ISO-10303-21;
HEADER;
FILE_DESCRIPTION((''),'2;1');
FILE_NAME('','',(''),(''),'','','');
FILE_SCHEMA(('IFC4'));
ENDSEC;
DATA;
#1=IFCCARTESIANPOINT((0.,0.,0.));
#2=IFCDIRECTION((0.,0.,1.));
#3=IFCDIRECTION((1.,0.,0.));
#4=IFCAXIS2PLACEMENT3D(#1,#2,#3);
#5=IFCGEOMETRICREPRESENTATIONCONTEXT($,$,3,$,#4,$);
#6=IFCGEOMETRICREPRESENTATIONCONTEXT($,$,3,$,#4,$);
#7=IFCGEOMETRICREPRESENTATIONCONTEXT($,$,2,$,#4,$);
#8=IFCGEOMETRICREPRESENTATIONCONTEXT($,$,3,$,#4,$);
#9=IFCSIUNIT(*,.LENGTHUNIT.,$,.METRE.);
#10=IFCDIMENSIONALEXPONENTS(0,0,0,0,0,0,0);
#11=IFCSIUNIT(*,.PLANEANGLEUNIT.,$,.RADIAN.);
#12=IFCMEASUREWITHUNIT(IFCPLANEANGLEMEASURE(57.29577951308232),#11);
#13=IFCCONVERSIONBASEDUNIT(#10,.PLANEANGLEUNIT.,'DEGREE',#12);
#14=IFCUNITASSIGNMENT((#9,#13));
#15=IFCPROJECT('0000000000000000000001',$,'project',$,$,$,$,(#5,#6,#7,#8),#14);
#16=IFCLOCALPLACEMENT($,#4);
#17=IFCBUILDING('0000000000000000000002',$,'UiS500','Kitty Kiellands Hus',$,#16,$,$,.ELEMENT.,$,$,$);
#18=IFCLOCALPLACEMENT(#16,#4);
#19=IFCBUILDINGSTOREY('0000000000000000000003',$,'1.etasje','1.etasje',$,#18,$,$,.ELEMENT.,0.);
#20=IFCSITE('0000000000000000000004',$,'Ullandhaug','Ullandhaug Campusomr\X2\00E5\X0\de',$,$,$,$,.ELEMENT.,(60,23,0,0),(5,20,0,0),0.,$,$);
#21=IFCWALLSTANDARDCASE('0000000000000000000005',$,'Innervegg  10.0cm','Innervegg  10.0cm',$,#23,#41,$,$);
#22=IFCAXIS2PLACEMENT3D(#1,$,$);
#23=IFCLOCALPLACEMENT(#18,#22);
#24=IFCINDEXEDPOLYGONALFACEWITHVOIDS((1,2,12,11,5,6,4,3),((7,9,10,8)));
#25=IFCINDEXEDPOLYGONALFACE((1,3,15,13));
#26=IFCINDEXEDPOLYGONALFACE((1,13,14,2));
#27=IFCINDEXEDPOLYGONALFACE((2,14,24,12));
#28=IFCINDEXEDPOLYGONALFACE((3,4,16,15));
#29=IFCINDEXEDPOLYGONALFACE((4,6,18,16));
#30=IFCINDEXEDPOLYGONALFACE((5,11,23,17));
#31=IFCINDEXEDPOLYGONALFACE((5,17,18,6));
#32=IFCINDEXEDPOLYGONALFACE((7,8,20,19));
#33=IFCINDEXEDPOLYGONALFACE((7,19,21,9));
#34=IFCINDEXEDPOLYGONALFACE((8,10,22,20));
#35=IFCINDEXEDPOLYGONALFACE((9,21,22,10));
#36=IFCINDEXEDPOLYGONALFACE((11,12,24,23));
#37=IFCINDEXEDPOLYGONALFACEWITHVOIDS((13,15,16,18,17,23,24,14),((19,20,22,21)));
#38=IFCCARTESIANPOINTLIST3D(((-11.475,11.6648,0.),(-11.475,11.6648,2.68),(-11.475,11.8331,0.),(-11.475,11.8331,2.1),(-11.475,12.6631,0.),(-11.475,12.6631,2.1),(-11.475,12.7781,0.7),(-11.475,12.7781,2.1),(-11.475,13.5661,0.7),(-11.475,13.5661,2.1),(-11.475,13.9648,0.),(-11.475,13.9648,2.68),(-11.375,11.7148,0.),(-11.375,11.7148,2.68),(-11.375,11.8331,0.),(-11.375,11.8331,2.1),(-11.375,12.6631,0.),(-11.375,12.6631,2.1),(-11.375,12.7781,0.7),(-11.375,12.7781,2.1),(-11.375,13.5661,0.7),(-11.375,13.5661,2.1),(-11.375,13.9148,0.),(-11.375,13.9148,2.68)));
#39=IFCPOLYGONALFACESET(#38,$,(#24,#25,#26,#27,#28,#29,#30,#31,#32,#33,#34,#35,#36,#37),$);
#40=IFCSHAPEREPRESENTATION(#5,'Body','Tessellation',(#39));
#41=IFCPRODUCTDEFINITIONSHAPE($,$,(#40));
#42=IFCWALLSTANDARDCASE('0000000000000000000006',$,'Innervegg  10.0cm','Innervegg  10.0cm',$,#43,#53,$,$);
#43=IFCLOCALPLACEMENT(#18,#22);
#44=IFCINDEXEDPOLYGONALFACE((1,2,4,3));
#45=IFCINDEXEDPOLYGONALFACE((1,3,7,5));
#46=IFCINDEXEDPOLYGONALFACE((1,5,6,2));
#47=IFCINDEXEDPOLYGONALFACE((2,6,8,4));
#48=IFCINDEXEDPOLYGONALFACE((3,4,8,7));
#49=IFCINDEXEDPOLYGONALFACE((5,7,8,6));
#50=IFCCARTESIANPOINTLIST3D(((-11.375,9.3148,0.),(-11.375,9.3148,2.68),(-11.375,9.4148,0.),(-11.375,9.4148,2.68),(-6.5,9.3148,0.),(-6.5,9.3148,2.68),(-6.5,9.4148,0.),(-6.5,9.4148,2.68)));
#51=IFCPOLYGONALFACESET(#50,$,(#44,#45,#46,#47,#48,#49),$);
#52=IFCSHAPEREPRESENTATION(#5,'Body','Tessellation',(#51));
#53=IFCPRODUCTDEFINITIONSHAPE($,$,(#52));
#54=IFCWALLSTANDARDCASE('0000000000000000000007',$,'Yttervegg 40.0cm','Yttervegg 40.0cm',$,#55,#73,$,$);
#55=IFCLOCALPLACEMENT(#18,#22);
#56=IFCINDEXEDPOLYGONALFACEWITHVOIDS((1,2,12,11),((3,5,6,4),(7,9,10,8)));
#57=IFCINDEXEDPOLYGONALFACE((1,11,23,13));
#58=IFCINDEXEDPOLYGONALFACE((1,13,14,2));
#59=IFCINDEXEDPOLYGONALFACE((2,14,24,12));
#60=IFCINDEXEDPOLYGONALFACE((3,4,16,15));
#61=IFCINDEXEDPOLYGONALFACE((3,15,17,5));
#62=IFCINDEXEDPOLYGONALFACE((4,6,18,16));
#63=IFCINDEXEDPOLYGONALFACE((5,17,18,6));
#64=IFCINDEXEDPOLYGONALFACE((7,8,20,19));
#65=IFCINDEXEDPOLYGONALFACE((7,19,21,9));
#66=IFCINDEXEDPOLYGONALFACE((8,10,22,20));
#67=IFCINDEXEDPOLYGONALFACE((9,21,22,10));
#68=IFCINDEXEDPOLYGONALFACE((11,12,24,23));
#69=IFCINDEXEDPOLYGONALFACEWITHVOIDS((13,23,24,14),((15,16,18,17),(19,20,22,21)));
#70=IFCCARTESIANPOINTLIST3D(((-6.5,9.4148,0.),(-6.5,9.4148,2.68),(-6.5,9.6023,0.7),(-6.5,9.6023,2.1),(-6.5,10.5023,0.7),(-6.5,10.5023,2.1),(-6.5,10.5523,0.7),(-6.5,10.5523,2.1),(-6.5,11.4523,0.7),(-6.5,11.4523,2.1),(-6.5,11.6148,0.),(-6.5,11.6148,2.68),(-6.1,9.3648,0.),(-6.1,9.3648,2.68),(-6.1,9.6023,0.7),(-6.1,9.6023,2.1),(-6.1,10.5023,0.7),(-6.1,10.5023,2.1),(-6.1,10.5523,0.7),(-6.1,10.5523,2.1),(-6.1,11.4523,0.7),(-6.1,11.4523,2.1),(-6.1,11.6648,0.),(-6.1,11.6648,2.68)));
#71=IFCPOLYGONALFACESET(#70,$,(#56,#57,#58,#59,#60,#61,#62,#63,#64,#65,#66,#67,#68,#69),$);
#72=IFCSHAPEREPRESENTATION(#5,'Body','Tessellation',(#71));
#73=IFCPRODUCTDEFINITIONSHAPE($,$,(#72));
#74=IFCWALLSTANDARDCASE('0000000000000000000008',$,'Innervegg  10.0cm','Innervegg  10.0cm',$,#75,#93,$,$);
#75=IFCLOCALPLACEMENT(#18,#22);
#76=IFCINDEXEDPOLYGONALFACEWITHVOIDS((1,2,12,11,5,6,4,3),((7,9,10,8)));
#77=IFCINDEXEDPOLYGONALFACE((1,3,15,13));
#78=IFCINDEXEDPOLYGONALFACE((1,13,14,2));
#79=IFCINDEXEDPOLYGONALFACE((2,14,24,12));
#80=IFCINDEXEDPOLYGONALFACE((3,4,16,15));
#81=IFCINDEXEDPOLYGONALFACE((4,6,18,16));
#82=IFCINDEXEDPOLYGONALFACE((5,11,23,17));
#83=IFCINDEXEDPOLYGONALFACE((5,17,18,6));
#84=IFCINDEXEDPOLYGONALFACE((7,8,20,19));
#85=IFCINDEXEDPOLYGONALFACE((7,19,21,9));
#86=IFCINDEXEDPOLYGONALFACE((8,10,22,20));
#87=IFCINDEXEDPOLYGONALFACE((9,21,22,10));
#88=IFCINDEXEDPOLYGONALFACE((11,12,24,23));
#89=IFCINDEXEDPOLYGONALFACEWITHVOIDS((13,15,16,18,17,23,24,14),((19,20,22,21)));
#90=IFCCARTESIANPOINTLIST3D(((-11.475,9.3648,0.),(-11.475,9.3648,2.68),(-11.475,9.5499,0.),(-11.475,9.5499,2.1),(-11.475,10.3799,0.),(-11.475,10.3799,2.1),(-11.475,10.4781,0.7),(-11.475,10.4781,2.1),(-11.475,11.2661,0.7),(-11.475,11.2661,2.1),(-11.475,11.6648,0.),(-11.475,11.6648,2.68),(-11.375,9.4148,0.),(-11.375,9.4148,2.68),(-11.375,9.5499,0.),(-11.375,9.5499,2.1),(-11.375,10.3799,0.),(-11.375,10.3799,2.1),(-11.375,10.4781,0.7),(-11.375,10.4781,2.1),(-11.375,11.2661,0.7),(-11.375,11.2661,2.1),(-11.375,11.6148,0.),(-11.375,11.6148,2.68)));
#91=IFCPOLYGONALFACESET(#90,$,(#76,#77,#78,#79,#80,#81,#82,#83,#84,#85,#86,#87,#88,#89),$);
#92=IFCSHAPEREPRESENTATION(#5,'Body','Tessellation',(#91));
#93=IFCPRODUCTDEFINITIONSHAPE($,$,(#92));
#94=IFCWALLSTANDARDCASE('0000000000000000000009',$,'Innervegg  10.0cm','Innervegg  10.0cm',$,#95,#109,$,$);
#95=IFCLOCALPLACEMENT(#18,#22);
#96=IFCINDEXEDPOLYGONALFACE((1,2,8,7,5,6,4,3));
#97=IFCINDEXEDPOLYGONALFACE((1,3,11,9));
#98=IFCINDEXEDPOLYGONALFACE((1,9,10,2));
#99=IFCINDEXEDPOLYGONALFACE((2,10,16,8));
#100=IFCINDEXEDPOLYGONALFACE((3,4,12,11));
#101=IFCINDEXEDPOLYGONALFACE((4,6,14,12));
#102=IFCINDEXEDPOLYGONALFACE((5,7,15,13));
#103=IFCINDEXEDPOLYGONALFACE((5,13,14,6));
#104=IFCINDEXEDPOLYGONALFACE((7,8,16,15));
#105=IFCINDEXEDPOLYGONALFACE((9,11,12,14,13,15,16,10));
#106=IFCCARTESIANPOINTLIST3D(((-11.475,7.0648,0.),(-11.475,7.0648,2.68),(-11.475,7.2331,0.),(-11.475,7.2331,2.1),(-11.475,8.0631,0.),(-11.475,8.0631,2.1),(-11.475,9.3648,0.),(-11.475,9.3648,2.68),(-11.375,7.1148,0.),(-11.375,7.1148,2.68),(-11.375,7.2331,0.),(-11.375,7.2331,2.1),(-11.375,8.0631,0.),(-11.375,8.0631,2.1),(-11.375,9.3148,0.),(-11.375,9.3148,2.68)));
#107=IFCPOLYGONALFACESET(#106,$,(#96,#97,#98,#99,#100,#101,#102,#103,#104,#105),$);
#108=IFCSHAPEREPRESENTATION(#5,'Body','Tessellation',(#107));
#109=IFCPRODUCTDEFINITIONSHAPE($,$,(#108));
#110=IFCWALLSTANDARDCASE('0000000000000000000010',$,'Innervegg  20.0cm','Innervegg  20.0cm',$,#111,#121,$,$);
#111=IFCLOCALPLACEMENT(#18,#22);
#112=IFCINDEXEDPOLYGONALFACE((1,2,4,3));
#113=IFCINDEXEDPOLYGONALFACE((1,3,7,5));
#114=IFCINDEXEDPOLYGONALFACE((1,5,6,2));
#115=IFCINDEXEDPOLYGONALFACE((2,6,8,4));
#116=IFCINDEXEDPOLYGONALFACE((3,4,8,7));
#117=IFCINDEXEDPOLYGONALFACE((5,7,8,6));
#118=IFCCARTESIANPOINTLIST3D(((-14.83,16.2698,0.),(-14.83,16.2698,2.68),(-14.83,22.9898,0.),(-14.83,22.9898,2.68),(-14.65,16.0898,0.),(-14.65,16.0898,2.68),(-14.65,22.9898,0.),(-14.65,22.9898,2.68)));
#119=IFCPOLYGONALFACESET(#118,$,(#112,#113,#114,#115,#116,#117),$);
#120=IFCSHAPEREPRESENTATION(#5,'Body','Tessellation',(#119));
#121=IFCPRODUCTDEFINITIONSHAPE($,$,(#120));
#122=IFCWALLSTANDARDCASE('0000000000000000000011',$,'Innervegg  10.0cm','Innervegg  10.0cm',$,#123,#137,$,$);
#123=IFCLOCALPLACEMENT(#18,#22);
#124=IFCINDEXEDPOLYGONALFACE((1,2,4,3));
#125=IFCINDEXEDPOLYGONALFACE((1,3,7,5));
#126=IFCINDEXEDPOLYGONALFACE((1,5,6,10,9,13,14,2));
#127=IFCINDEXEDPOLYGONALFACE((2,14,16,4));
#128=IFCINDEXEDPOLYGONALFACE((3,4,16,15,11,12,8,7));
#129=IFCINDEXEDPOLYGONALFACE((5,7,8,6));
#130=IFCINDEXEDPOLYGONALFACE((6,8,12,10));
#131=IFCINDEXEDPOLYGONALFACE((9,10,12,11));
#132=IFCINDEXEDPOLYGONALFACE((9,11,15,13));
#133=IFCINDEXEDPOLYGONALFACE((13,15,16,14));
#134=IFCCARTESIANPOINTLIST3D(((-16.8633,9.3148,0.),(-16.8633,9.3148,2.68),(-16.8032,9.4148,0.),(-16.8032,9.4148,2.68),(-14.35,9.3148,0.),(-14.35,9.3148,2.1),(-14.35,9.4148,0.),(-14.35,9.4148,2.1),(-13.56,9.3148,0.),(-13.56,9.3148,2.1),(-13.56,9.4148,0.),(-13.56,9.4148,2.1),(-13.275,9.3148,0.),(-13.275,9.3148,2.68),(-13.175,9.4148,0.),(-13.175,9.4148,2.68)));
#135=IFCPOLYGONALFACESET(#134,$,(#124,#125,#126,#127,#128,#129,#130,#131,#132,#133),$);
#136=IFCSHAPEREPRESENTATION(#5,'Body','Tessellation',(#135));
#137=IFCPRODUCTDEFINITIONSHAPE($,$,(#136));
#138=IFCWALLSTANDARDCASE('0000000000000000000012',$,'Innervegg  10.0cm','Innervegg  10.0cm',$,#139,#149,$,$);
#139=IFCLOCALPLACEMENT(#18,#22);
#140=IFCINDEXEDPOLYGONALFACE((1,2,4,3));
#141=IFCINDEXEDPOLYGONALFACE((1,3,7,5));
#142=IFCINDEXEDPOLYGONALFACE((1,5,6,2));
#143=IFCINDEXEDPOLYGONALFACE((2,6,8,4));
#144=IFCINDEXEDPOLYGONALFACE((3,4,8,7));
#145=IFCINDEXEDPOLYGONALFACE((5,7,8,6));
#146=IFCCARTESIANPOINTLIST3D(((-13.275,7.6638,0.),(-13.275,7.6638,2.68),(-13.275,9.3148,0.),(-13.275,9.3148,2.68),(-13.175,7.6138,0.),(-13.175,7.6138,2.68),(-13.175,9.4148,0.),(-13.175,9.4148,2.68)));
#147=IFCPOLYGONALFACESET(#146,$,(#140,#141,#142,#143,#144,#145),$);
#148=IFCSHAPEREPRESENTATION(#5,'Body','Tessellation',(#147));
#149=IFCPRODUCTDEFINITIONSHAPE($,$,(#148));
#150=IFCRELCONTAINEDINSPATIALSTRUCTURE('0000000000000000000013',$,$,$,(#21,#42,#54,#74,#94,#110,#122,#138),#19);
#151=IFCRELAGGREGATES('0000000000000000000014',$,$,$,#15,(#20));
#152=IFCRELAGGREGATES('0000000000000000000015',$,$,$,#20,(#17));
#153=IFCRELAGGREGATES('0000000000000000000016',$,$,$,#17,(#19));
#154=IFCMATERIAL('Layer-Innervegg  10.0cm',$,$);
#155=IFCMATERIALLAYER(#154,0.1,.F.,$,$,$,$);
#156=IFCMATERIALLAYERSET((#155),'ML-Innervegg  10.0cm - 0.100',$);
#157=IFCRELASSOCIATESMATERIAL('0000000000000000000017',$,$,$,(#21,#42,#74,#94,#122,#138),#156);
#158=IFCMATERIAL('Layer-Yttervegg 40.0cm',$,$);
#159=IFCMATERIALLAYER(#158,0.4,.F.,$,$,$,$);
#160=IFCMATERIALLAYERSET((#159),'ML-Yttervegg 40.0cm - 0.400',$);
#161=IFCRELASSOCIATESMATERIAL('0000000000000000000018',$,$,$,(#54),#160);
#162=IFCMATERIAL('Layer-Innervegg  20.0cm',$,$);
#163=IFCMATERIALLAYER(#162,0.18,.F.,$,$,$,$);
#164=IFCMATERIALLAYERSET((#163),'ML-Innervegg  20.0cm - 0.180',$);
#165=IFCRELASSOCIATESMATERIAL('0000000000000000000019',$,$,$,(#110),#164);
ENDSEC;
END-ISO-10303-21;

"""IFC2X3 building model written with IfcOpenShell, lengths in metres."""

from ifc_helpers import new_model, entity, si_unit, converted_unit, frame, origin_with_axes, place, context, project, spatial, polyline, outline, extrude, material, layer, layer_set, layer_usage, element, save


model = new_model("IFC2X3")

# Units and contexts
context_of_model_1 = context(None, 3, world=origin_with_axes())
context_of_model_2 = context(None, 3, world=origin_with_axes())
context_of_model_3 = context(None, 2, world=origin_with_axes())
context_of_model_4 = context(None, 3, world=origin_with_axes())
ifc_project = project(units=[si_unit("LENGTHUNIT", "METRE"), converted_unit("PLANEANGLEUNIT", "DEGREE", entity("IfcPlaneAngleMeasure", 57.29577951308232), si_unit("PLANEANGLEUNIT", "RADIAN"), dimensions=[0, 0, 0, 0, 0, 0, 0])], contexts=[context_of_model_1, context_of_model_2, context_of_model_3, context_of_model_4])

# Site, building, storey
site = spatial("IfcSite", under=ifc_project, Name="Ullandhaug", Description="Ullandhaug Campusområde", CompositionType="ELEMENT", RefLatitude=(60, 23, 0, 0), RefLongitude=(5, 20, 0, 0), RefElevation=0.0)
building_placement = place(None, origin_with_axes())
building = spatial("IfcBuilding", under=site, at=building_placement, Name="UiS500", Description="Kitty Kiellands Hus", CompositionType="ELEMENT")
storey_placement = place(building_placement, origin_with_axes())
storey = spatial("IfcBuildingStorey", under=building, at=storey_placement, Name="1.etasje", Description="1.etasje", CompositionType="ELEMENT", Elevation=0.0)

# Shared definitions
ifc_material_1 = material(Name="Layer-Innervegg  10.0cm")
ifc_layer_1 = layer(ifc_material_1, 0.1, ventilated=False)
ifc_layer_set_1 = layer_set([ifc_layer_1], Name="ML-Innervegg  10.0cm - 0.100")
ifc_layer_usage_1 = layer_usage(ifc_layer_set_1, "AXIS2", "POSITIVE", 0.0)

# Shared definitions
ifc_material_2 = material(Name="Layer-Yttervegg 40.0cm")
ifc_layer_2 = layer(ifc_material_2, 0.4, ventilated=False)
ifc_layer_set_2 = layer_set([ifc_layer_2], Name="ML-Yttervegg 40.0cm - 0.400")
ifc_layer_usage_2 = layer_usage(ifc_layer_set_2, "AXIS2", "POSITIVE", 0.0)

# Wall, openings
wall_1_placement = place(storey_placement, frame((-11.475, 13.9648, 0.0), z_axis=(0.0, 0.0, 1.0), x_axis=(0.0, -1.0, 0.0)))
wall_1 = element("IfcWallStandardCase", 1, at=wall_1_placement, inside=storey, material=ifc_layer_usage_1, Name="Innervegg  10.0cm", Description="Innervegg  10.0cm", context=context_of_model_1, shape_type="SweptSolid", body=[
    extrude(outline(polyline([(0.0, 0.0), (2.3, 0.0), (2.25, 0.1), (0.05, 0.1), (0.0, 0.0)])), frame((0.0, 0.0, 0.0), z_axis=(0.0, 0.0, 1.0), x_axis=(1.0, 0.0, 0.0)), (0.0, 0.0, 1.0), 2.68),
])
opening_1_placement = place(wall_1_placement, frame((1.3016, 0.1, 0.0), z_axis=(0.0, 0.0, 1.0), x_axis=(1.0, 0.0, 0.0)))
element("IfcOpeningElement", 2, at=opening_1_placement, cuts=wall_1, context=context_of_model_1, shape_type="SweptSolid", body=[
    extrude(outline(polyline([(0.0, 0.0), (2.1, 0.0), (2.1, 0.83), (0.0, 0.83), (0.0, 0.0)])), frame((0.0, 0.0, 0.0), z_axis=(0.0, 1.0, 0.0), x_axis=(0.0, 0.0, 1.0)), (0.0, 0.0, -1.0), 0.1),
])
opening_2_placement = place(wall_1_placement, frame((0.3986, 0.1, 0.7), z_axis=(0.0, 0.0, 1.0), x_axis=(1.0, 0.0, 0.0)))
element("IfcOpeningElement", 3, at=opening_2_placement, cuts=wall_1, context=context_of_model_1, shape_type="SweptSolid", body=[
    extrude(outline(polyline([(0.0, 0.0), (1.4, 0.0), (1.4, 0.788), (0.0, 0.788), (0.0, 0.0)])), frame((0.0, 0.0, 0.0), z_axis=(0.0, 1.0, 0.0), x_axis=(0.0, 0.0, 1.0)), (0.0, 0.0, -1.0), 0.1),
])

# Wall
wall_2_placement = place(storey_placement, frame((-11.375, 9.3148, 0.0), z_axis=(0.0, 0.0, 1.0), x_axis=(1.0, 0.0, 0.0)))
element("IfcWallStandardCase", 4, at=wall_2_placement, inside=storey, material=ifc_layer_usage_1, Name="Innervegg  10.0cm", Description="Innervegg  10.0cm", context=context_of_model_1, shape_type="SweptSolid", body=[
    extrude(outline(polyline([(0.0, 0.0), (4.875, 0.0), (4.875, 0.1), (0.0, 0.1), (0.0, 0.0)])), origin_with_axes(), (0.0, 0.0, 1.0), 2.68),
])

# Walls, openings
wall_3_placement = place(storey_placement, frame((-6.1, 9.3648, 0.0), z_axis=(0.0, 0.0, 1.0), x_axis=(0.0, 1.0, 0.0)))
wall_3 = element("IfcWallStandardCase", 5, at=wall_3_placement, inside=storey, material=ifc_layer_usage_2, Name="Yttervegg 40.0cm", Description="Yttervegg 40.0cm", context=context_of_model_1, shape_type="SweptSolid", body=[
    extrude(outline(polyline([(0.0, 0.0), (2.3, 0.0), (2.25, 0.4), (0.05, 0.4), (0.0, 0.0)])), frame((0.0, 0.0, 0.0), z_axis=(0.0, 0.0, 1.0), x_axis=(1.0, 0.0, 0.0)), (0.0, 0.0, 1.0), 2.68),
])
opening_3_placement = place(wall_3_placement, frame((0.2375, 0.4, 0.7), z_axis=(0.0, 0.0, 1.0), x_axis=(1.0, 0.0, 0.0)))
element("IfcOpeningElement", 6, at=opening_3_placement, cuts=wall_3, context=context_of_model_1, shape_type="SweptSolid", body=[
    extrude(outline(polyline([(0.0, 0.0), (1.4, 0.0), (1.4, 0.9), (0.0, 0.9), (0.0, 0.0)])), frame((0.0, 0.0, 0.0), z_axis=(0.0, 1.0, 0.0), x_axis=(0.0, 0.0, 1.0)), (0.0, 0.0, -1.0), 0.4),
])
opening_4_placement = place(wall_3_placement, frame((1.1875, 0.4, 0.7), z_axis=(0.0, 0.0, 1.0), x_axis=(1.0, 0.0, 0.0)))
element("IfcOpeningElement", 7, at=opening_4_placement, cuts=wall_3, context=context_of_model_1, shape_type="SweptSolid", body=[
    extrude(outline(polyline([(0.0, 0.0), (1.4, 0.0), (1.4, 0.9), (0.0, 0.9), (0.0, 0.0)])), frame((0.0, 0.0, 0.0), z_axis=(0.0, 1.0, 0.0), x_axis=(0.0, 0.0, 1.0)), (0.0, 0.0, -1.0), 0.4),
])
wall_4_placement = place(storey_placement, frame((-11.475, 11.6648, 0.0), z_axis=(0.0, 0.0, 1.0), x_axis=(0.0, -1.0, 0.0)))
wall_4 = element("IfcWallStandardCase", 8, at=wall_4_placement, inside=storey, material=ifc_layer_usage_1, Name="Innervegg  10.0cm", Description="Innervegg  10.0cm", context=context_of_model_1, shape_type="SweptSolid", body=[
    extrude(outline(polyline([(0.0, 0.0), (2.3, 0.0), (2.25, 0.1), (0.05, 0.1), (0.0, 0.0)])), frame((0.0, 0.0, 0.0), z_axis=(0.0, 0.0, 1.0), x_axis=(1.0, 0.0, 0.0)), (0.0, 0.0, 1.0), 2.68),
])
opening_5_placement = place(wall_4_placement, frame((1.2849, 0.1, 0.0), z_axis=(0.0, 0.0, 1.0), x_axis=(1.0, 0.0, 0.0)))
element("IfcOpeningElement", 9, at=opening_5_placement, cuts=wall_4, context=context_of_model_1, shape_type="SweptSolid", body=[
    extrude(outline(polyline([(0.0, 0.0), (2.1, 0.0), (2.1, 0.83), (0.0, 0.83), (0.0, 0.0)])), frame((0.0, 0.0, 0.0), z_axis=(0.0, 1.0, 0.0), x_axis=(0.0, 0.0, 1.0)), (0.0, 0.0, -1.0), 0.1),
])
opening_6_placement = place(wall_4_placement, frame((0.3986, 0.1, 0.7), z_axis=(0.0, 0.0, 1.0), x_axis=(1.0, 0.0, 0.0)))
element("IfcOpeningElement", 10, at=opening_6_placement, cuts=wall_4, context=context_of_model_1, shape_type="SweptSolid", body=[
    extrude(outline(polyline([(0.0, 0.0), (1.4, 0.0), (1.4, 0.788), (0.0, 0.788), (0.0, 0.0)])), frame((0.0, 0.0, 0.0), z_axis=(0.0, 1.0, 0.0), x_axis=(0.0, 0.0, 1.0)), (0.0, 0.0, -1.0), 0.1),
])

# Wall, opening
wall_5_placement = place(storey_placement, frame((-11.475, 9.3648, 0.0), z_axis=(0.0, 0.0, 1.0), x_axis=(0.0, -1.0, 0.0)))
wall_5 = element("IfcWallStandardCase", 11, at=wall_5_placement, inside=storey, material=ifc_layer_usage_1, Name="Innervegg  10.0cm", Description="Innervegg  10.0cm", context=context_of_model_1, shape_type="SweptSolid", body=[
    extrude(outline(polyline([(0.0, 0.0), (2.3, 0.0), (2.25, 0.1), (0.05, 0.1), (0.0, 0.0)])), frame((0.0, 0.0, 0.0), z_axis=(0.0, 0.0, 1.0), x_axis=(1.0, 0.0, 0.0)), (0.0, 0.0, 1.0), 2.68),
])
opening_7_placement = place(wall_5_placement, frame((1.3016, 0.1, 0.0), z_axis=(0.0, 0.0, 1.0), x_axis=(1.0, 0.0, 0.0)))
element("IfcOpeningElement", 12, at=opening_7_placement, cuts=wall_5, context=context_of_model_1, shape_type="SweptSolid", body=[
    extrude(outline(polyline([(0.0, 0.0), (2.1, 0.0), (2.1, 0.83), (0.0, 0.83), (0.0, 0.0)])), frame((0.0, 0.0, 0.0), z_axis=(0.0, 1.0, 0.0), x_axis=(0.0, 0.0, 1.0)), (0.0, 0.0, -1.0), 0.1),
])

# Wall
ifc_material_3 = material(Name="Layer-Innervegg  20.0cm")
ifc_layer_3 = layer(ifc_material_3, 0.18, ventilated=False)
ifc_layer_set_3 = layer_set([ifc_layer_3], Name="ML-Innervegg  20.0cm - 0.180")
ifc_layer_usage_3 = layer_usage(ifc_layer_set_3, "AXIS2", "POSITIVE", 0.0)
wall_6_placement = place(storey_placement, frame((-14.65, 16.0898, 0.0), z_axis=(0.0, 0.0, 1.0), x_axis=(0.0, 1.0, 0.0)))
element("IfcWallStandardCase", 13, at=wall_6_placement, inside=storey, material=ifc_layer_usage_3, Name="Innervegg  20.0cm", Description="Innervegg  20.0cm", context=context_of_model_1, shape_type="SweptSolid", body=[
    extrude(outline(polyline([(0.0, 0.0), (6.9, 0.0), (6.9, 0.18), (0.18, 0.18), (0.0, 0.0)])), frame((0.0, 0.0, 0.0), z_axis=(0.0, 0.0, 1.0), x_axis=(1.0, 0.0, 0.0)), (0.0, 0.0, 1.0), 2.68),
])

# Wall, opening
wall_7_placement = place(storey_placement, frame((-16.8633, 9.3148, 0.0), z_axis=(0.0, 0.0, 1.0), x_axis=(1.0, 0.0, 0.0)))
wall_7 = element("IfcWallStandardCase", 14, at=wall_7_placement, inside=storey, material=ifc_layer_usage_1, Name="Innervegg  10.0cm", Description="Innervegg  10.0cm", context=context_of_model_1, shape_type="SweptSolid", body=[
    extrude(outline(polyline([(0.0, 0.0), (3.5883, 0.0), (3.6883, 0.1), (0.0602, 0.1), (0.0, 0.0)])), origin_with_axes(), (0.0, 0.0, 1.0), 2.68),
])
opening_8_placement = place(wall_7_placement, frame((2.5133, 0.1, 0.0), z_axis=(0.0, 0.0, 1.0), x_axis=(1.0, 0.0, 0.0)))
element("IfcOpeningElement", 15, at=opening_8_placement, cuts=wall_7, context=context_of_model_1, shape_type="SweptSolid", body=[
    extrude(outline(polyline([(0.0, 0.0), (2.1, 0.0), (2.1, 0.79), (0.0, 0.79), (0.0, 0.0)])), frame((0.0, 0.0, 0.0), z_axis=(0.0, 1.0, 0.0), x_axis=(0.0, 0.0, 1.0)), (0.0, 0.0, -1.0), 0.1),
])

# Wall
wall_8_placement = place(storey_placement, frame((-13.275, 9.3148, 0.0), z_axis=(0.0, 0.0, 1.0), x_axis=(0.0, -1.0, 0.0)))
element("IfcWallStandardCase", 16, at=wall_8_placement, inside=storey, material=ifc_layer_usage_1, Name="Innervegg  10.0cm", Description="Innervegg  10.0cm", context=context_of_model_1, shape_type="SweptSolid", body=[
    extrude(outline(polyline([(0.0, 0.0), (1.651, 0.0), (1.701, 0.1), (-0.1, 0.1), (0.0, 0.0)])), frame((0.0, 0.0, 0.0), z_axis=(0.0, 0.0, 1.0), x_axis=(1.0, 0.0, 0.0)), (0.0, 0.0, 1.0), 2.68),
])

save(model, "model.ifc")
